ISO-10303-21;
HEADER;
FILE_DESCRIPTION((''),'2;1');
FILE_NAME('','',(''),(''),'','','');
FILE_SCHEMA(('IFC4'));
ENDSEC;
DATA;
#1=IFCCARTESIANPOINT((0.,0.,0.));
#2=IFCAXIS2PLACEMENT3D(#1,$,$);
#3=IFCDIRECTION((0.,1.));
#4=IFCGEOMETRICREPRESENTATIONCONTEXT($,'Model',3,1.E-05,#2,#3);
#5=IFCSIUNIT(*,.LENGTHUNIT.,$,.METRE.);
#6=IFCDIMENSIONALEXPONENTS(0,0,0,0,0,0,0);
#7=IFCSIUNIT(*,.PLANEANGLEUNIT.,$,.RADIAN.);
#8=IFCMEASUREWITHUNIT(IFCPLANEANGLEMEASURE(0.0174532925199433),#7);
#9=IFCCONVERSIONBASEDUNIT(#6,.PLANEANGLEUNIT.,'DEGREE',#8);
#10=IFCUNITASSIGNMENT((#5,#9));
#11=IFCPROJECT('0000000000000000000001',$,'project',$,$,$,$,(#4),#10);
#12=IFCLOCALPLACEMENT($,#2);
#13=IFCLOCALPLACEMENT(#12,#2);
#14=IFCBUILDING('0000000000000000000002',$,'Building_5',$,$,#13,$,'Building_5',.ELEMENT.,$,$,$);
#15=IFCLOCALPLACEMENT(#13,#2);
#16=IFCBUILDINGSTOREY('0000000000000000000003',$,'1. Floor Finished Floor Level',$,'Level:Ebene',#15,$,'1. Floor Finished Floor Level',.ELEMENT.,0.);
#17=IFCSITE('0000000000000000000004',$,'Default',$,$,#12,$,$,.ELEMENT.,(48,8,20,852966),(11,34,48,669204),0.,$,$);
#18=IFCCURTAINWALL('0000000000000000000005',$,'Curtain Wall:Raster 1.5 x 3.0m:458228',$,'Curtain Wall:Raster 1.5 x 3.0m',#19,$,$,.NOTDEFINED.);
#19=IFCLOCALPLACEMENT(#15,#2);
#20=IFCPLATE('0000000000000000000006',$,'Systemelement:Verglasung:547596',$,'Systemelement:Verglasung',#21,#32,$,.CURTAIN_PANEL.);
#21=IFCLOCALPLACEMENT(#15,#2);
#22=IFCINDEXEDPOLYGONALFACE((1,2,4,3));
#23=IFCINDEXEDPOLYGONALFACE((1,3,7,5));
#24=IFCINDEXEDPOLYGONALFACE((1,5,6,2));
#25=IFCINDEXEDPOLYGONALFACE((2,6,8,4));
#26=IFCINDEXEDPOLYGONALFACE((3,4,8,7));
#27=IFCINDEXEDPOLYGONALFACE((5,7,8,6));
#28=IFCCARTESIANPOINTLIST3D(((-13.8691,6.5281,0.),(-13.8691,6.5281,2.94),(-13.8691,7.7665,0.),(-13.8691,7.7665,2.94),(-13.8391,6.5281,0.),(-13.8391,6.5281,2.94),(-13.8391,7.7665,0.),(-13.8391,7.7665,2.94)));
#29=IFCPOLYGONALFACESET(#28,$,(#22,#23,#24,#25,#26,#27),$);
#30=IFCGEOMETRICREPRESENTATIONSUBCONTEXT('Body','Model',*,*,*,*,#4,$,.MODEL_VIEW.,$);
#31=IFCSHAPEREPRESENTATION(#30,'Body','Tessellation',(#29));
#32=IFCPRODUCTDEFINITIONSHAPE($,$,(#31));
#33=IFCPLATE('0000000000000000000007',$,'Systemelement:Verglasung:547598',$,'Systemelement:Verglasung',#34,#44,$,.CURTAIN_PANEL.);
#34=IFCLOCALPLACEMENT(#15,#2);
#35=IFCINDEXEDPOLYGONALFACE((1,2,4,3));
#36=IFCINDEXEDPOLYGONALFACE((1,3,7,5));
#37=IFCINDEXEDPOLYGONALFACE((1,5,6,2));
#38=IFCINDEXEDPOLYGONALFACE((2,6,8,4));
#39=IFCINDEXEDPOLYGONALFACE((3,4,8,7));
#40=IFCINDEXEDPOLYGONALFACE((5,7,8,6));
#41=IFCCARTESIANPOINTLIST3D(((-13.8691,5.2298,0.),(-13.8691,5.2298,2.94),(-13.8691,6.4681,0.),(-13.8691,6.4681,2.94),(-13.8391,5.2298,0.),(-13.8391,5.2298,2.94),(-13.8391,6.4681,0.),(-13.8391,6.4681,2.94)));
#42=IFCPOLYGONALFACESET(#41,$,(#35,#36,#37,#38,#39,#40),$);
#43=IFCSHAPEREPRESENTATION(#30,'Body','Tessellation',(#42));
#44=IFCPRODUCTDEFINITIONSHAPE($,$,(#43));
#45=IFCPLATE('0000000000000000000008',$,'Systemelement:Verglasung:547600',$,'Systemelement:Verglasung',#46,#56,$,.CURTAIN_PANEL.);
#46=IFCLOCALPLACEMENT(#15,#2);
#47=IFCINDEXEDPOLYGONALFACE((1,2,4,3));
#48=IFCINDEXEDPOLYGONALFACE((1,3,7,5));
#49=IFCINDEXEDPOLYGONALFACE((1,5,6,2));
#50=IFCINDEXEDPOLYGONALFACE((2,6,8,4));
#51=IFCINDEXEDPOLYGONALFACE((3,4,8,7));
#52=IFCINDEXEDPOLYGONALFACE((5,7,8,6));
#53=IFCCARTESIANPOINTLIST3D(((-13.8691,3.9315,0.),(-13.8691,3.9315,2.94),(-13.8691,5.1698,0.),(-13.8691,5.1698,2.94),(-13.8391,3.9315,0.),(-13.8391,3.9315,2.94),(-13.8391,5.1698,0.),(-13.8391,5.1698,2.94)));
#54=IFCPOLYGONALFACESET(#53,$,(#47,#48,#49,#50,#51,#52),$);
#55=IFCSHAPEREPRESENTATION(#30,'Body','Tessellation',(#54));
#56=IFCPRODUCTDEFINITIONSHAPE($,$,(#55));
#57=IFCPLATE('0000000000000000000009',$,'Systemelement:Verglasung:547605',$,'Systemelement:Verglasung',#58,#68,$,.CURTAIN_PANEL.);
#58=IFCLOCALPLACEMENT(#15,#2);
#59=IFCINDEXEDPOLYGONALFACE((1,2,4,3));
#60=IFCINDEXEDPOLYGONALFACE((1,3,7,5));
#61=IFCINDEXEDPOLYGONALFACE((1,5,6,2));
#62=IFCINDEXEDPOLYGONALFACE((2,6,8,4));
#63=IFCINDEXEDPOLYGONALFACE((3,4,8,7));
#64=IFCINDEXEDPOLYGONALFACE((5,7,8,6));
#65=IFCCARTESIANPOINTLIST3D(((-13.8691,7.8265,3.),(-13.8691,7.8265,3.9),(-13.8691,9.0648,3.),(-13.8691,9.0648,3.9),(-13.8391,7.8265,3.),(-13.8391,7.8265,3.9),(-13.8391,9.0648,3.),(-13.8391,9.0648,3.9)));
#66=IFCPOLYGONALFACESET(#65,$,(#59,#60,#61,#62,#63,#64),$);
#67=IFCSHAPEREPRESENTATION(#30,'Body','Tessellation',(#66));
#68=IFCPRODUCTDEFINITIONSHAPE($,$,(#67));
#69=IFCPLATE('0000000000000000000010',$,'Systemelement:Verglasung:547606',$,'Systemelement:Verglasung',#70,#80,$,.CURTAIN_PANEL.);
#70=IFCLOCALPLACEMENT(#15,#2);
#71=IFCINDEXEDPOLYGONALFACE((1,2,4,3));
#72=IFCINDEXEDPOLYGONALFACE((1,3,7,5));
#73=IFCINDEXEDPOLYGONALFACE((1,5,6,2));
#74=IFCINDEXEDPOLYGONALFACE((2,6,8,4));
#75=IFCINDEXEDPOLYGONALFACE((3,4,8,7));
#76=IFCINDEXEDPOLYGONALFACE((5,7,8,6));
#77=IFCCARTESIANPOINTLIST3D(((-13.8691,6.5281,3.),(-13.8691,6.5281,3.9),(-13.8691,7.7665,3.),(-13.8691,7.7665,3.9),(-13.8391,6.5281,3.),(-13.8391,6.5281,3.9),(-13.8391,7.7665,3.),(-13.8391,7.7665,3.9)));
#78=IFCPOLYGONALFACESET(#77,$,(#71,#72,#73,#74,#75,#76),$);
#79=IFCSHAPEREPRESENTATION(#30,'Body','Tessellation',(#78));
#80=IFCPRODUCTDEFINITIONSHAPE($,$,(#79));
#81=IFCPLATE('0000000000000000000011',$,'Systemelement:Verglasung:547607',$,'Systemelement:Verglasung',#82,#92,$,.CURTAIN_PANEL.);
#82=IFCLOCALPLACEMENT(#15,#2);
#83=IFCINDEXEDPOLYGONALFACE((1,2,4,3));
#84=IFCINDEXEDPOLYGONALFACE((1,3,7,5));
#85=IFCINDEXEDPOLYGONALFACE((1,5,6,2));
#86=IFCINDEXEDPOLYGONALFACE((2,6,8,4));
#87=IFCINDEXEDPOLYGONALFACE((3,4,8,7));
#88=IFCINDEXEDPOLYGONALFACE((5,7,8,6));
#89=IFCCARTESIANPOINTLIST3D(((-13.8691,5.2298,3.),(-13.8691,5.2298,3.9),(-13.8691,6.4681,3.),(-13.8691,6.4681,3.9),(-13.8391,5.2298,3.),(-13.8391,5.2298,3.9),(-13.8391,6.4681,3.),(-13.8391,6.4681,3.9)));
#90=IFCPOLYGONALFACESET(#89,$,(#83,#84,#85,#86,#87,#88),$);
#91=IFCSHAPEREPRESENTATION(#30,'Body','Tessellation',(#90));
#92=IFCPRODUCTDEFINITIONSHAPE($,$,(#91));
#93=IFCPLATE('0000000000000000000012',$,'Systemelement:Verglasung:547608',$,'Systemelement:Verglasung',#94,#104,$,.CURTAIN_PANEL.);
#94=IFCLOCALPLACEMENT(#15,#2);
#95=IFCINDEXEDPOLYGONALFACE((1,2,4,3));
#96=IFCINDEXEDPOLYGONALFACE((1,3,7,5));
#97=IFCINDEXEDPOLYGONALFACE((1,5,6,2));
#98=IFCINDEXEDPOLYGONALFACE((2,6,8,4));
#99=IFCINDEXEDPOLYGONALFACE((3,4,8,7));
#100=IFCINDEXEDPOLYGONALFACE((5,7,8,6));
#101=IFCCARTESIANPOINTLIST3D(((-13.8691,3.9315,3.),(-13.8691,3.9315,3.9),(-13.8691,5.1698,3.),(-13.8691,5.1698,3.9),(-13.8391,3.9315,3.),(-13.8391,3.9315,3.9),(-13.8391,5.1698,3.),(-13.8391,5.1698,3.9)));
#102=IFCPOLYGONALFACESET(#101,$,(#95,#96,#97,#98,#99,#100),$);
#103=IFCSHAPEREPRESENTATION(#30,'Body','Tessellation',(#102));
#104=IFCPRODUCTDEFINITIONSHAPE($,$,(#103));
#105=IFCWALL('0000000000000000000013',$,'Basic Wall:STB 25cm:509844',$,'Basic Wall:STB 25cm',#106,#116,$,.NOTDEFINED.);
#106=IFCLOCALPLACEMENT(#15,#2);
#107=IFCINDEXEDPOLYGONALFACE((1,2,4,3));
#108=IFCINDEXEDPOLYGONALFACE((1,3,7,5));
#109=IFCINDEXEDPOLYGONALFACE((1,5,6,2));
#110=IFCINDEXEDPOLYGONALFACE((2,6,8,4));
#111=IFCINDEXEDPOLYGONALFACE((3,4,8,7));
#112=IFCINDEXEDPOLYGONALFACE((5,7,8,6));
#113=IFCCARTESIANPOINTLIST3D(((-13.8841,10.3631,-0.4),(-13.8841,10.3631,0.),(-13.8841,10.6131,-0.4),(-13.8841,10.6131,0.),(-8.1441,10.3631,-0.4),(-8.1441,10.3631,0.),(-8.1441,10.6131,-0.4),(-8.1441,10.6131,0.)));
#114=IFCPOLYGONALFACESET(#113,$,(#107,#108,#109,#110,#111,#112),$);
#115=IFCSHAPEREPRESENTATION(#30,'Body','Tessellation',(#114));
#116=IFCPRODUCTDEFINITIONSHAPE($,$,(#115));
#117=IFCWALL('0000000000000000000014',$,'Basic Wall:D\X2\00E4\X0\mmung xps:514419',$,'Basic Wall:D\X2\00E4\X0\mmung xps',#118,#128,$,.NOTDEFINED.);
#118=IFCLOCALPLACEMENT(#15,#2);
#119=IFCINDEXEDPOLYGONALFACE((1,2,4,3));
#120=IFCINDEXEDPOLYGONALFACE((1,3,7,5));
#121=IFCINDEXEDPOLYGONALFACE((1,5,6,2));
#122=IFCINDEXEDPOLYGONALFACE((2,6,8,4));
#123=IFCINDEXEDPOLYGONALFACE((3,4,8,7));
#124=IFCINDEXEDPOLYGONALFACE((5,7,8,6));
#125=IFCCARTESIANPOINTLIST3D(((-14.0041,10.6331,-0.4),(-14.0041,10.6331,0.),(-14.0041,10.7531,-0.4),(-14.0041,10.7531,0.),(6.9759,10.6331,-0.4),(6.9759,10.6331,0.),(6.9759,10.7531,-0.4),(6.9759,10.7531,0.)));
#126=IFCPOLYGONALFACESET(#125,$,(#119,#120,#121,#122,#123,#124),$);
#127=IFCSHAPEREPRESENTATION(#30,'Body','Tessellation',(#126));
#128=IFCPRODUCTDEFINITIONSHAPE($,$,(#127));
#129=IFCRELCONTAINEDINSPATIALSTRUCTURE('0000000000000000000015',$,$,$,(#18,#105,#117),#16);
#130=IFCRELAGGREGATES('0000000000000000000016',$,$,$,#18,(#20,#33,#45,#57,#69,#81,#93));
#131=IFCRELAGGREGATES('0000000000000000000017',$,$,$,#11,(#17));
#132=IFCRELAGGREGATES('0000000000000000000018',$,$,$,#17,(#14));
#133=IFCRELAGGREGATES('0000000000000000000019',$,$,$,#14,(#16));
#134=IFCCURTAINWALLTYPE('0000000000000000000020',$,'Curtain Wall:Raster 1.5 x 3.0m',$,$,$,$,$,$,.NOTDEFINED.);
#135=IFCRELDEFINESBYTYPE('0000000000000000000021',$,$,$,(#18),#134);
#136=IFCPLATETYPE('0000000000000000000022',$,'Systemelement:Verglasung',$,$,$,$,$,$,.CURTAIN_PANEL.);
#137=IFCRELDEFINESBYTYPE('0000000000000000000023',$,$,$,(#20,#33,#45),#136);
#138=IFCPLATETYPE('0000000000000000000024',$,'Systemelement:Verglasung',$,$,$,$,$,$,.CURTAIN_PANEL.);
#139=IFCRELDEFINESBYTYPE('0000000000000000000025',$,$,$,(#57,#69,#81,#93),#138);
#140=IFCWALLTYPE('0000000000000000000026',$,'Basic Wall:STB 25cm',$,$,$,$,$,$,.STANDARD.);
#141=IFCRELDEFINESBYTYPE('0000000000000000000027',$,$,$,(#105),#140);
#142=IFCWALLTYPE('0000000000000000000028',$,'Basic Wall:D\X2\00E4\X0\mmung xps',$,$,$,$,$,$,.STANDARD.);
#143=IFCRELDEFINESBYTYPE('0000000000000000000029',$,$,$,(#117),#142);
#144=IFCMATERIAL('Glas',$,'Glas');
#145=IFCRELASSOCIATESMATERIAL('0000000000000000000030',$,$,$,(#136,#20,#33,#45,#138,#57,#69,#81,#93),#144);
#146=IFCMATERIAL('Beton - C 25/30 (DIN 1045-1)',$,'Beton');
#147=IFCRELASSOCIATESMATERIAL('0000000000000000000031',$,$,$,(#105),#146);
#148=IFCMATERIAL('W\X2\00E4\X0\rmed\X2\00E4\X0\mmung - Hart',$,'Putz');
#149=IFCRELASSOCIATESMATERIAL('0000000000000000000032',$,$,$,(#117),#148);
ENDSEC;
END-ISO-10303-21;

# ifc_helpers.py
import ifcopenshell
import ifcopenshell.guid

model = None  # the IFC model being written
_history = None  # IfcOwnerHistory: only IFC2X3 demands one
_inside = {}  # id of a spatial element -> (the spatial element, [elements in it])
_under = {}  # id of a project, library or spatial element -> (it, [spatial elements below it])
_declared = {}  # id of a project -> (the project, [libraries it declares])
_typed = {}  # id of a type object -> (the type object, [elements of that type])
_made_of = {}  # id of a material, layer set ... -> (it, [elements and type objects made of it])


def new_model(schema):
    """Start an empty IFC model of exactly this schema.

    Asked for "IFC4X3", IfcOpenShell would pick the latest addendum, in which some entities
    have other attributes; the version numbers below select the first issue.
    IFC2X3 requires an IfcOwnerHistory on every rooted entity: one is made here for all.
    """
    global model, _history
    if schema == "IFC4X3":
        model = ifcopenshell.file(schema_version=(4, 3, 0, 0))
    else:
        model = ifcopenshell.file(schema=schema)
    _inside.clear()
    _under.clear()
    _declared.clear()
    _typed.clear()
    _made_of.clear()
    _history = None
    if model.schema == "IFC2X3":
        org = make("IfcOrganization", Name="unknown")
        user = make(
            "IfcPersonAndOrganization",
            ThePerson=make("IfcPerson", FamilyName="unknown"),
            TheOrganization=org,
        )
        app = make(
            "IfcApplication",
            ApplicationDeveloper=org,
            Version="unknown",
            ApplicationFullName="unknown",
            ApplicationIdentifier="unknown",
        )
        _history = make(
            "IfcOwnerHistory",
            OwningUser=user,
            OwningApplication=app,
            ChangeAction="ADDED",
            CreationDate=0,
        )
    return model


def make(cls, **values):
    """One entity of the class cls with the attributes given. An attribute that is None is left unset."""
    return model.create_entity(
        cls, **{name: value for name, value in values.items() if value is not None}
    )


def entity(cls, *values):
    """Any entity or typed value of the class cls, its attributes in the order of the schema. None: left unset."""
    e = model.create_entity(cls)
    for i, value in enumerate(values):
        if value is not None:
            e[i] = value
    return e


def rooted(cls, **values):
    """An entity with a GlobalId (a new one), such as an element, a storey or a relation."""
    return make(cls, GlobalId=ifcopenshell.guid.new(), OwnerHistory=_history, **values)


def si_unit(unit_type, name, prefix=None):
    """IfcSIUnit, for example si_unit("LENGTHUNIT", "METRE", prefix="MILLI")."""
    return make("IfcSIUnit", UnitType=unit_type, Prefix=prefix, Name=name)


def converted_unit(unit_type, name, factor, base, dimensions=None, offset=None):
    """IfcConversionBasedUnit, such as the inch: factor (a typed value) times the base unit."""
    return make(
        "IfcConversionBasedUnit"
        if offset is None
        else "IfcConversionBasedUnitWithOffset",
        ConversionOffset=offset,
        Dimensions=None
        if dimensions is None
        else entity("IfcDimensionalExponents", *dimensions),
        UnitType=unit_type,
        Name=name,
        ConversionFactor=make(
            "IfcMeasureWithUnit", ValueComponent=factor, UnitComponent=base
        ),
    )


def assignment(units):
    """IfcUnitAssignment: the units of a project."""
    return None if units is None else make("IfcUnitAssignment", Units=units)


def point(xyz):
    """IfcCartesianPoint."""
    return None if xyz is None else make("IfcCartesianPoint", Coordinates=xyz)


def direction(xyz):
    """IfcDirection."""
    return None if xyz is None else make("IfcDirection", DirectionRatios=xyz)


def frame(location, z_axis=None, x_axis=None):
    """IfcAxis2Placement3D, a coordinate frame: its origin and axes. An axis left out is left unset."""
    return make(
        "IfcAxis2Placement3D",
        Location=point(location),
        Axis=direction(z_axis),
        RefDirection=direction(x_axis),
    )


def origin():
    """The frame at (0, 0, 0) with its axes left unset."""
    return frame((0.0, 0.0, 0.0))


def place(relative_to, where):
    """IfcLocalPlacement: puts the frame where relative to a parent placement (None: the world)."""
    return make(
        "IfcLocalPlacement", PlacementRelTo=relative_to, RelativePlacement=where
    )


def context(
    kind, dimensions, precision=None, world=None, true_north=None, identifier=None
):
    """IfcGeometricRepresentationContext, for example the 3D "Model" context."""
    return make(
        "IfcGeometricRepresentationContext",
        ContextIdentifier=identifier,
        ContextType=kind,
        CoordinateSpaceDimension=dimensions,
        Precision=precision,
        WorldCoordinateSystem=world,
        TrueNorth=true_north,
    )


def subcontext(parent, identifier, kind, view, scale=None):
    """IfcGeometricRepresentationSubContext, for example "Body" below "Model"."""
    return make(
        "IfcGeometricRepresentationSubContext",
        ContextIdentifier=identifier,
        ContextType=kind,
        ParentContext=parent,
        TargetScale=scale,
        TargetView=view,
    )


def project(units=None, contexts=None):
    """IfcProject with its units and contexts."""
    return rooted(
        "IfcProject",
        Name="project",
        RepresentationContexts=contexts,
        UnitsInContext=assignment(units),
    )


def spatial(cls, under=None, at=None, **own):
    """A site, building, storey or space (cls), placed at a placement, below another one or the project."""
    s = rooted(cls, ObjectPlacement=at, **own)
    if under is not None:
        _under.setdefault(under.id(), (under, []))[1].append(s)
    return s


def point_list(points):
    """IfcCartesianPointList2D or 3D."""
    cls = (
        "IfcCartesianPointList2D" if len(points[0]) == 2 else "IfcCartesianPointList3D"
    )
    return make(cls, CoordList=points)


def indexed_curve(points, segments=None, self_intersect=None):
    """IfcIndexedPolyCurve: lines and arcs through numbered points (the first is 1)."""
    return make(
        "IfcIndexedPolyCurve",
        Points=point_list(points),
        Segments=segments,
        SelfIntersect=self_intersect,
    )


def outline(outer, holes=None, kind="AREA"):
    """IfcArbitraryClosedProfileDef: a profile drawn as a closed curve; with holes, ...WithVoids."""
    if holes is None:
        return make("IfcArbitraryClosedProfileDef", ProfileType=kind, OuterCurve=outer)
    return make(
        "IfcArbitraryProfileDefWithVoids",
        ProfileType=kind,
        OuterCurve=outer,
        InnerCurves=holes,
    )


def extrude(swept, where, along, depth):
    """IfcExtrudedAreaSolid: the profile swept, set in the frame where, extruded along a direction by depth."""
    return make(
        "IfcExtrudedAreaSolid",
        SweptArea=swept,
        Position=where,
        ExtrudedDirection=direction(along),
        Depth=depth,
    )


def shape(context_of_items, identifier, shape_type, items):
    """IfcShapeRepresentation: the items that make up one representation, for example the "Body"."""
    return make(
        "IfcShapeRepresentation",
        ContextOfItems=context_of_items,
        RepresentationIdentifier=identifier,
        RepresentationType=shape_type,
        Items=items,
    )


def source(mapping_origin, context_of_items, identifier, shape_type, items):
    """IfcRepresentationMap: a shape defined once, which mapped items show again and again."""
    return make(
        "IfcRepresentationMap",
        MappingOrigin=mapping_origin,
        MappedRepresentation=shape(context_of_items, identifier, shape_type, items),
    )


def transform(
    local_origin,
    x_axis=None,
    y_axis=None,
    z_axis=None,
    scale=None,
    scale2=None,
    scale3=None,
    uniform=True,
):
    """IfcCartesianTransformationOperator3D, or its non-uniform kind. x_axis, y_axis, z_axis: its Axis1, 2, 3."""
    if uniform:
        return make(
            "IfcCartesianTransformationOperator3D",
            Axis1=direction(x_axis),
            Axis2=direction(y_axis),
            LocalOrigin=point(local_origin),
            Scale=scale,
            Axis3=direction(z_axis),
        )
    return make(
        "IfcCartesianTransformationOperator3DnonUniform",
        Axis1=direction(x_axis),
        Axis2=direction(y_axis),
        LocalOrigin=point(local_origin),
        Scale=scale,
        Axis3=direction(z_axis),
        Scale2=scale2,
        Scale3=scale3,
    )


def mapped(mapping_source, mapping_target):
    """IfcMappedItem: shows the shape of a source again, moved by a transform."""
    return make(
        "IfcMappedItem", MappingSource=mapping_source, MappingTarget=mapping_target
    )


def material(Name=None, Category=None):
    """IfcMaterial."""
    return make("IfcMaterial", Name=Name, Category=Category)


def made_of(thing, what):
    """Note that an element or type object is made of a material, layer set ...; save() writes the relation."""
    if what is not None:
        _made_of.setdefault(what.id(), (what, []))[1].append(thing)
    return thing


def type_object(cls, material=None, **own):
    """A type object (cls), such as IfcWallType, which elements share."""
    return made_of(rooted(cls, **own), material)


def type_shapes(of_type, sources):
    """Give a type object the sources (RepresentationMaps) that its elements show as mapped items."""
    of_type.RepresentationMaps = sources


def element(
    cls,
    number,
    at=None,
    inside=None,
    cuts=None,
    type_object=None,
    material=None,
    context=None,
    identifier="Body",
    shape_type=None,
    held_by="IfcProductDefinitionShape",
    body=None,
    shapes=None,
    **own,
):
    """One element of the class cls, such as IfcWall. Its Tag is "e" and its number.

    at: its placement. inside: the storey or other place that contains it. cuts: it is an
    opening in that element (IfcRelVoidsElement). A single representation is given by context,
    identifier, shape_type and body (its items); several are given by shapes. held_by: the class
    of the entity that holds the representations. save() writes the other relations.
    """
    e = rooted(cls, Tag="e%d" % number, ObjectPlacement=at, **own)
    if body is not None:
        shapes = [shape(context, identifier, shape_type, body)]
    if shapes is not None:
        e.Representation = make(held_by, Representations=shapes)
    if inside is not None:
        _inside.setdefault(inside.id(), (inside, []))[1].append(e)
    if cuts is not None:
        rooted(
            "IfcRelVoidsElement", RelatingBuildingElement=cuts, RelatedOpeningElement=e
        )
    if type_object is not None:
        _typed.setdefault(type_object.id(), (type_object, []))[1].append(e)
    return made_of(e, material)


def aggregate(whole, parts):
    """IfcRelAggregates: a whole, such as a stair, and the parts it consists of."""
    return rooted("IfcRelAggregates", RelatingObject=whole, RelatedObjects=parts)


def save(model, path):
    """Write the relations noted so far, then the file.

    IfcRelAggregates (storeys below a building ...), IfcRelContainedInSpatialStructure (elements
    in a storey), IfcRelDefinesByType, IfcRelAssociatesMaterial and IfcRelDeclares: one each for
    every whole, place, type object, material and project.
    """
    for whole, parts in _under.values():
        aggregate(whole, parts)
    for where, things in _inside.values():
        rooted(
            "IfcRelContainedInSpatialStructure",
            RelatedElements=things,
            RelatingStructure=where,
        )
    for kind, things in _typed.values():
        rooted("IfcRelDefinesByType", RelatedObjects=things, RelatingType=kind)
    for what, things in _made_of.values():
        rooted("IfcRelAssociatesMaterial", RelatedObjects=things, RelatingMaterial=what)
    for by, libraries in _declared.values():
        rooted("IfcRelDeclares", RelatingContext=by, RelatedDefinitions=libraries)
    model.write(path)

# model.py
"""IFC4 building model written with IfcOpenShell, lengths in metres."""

from ifc_helpers import new_model, entity, si_unit, converted_unit, direction, frame, origin, place, context, subcontext, project, spatial, indexed_curve, outline, extrude, source, transform, mapped, material, type_object, type_shapes, element, aggregate, save


model = new_model("IFC4")

# Units and contexts
model_context = context("Model", 3, precision=1e-05, world=origin(), true_north=direction((0.0, 1.0)))
body_context = subcontext(model_context, "Body", "Model", "MODEL_VIEW")
ifc_project = project(units=[si_unit("LENGTHUNIT", "METRE"), converted_unit("PLANEANGLEUNIT", "DEGREE", entity("IfcPlaneAngleMeasure", 0.0174532925199433), si_unit("PLANEANGLEUNIT", "RADIAN"), dimensions=[0, 0, 0, 0, 0, 0, 0])], contexts=[model_context])

# Site, building, storey
site_placement = place(None, origin())
site = spatial("IfcSite", under=ifc_project, at=site_placement, Name="Default", CompositionType="ELEMENT", RefLatitude=(48, 8, 20, 852966), RefLongitude=(11, 34, 48, 669204), RefElevation=0.0)
building_placement = place(site_placement, origin())
building = spatial("IfcBuilding", under=site, at=building_placement, Name="Building_5", LongName="Building_5", CompositionType="ELEMENT")
storey_placement = place(building_placement, origin())
storey = spatial("IfcBuildingStorey", under=building, at=storey_placement, Name="1. Floor Finished Floor Level", ObjectType="Level:Ebene", LongName="1. Floor Finished Floor Level", CompositionType="ELEMENT", Elevation=0.0)

# Curtain wall, plates
curtain_wall_type = type_object("IfcCurtainWallType", Name="Curtain Wall:Raster 1.5 x 3.0m", PredefinedType="NOTDEFINED")
curtain_wall_placement = place(storey_placement, origin())
curtain_wall = element("IfcCurtainWall", 1, at=curtain_wall_placement, inside=storey, type_object=curtain_wall_type, Name="Curtain Wall:Raster 1.5 x 3.0m:458228", ObjectType="Curtain Wall:Raster 1.5 x 3.0m", PredefinedType="NOTDEFINED")
ifc_material_1 = material(Name="Glas", Category="Glas")
plate_type_1 = type_object("IfcPlateType", Name="Systemelement:Verglasung", PredefinedType="CURTAIN_PANEL", material=ifc_material_1)
shared_shape_1 = source(origin(), body_context, "Body", "SweptSolid", [
    extrude(outline(indexed_curve([(-0.015, -0.6192), (0.015, -0.6192), (0.015, 0.6192), (-0.015, 0.6192), (-0.015, -0.6192)], self_intersect=False)), frame((0.0, 0.0, 0.0), z_axis=(0.0, 0.0, 1.0), x_axis=(0.0, 1.0, 0.0)), (0.0, 0.0, 1.0), 2.94),
])
type_shapes(plate_type_1, [shared_shape_1])
plate_1_placement = place(curtain_wall_placement, frame((-13.8541, 7.1473, 0.0), z_axis=(0.0, 0.0, 1.0), x_axis=(0.0, -1.0, 0.0)))
plate_1 = element("IfcPlate", 2, at=plate_1_placement, type_object=plate_type_1, material=ifc_material_1, Name="Systemelement:Verglasung:547596", ObjectType="Systemelement:Verglasung", PredefinedType="CURTAIN_PANEL", context=body_context, shape_type="MappedRepresentation", body=[
    mapped(shared_shape_1, transform((0.0, 0.0, 0.0), scale=1.0)),
])
plate_2_placement = place(curtain_wall_placement, frame((-13.8541, 5.849, 0.0), z_axis=(0.0, 0.0, 1.0), x_axis=(0.0, -1.0, 0.0)))
plate_2 = element("IfcPlate", 3, at=plate_2_placement, type_object=plate_type_1, material=ifc_material_1, Name="Systemelement:Verglasung:547598", ObjectType="Systemelement:Verglasung", PredefinedType="CURTAIN_PANEL", context=body_context, shape_type="MappedRepresentation", body=[
    mapped(shared_shape_1, transform((0.0, 0.0, 0.0), scale=1.0)),
])
plate_3_placement = place(curtain_wall_placement, frame((-13.8541, 4.5506, 0.0), z_axis=(0.0, 0.0, 1.0), x_axis=(0.0, -1.0, 0.0)))
plate_3 = element("IfcPlate", 4, at=plate_3_placement, type_object=plate_type_1, material=ifc_material_1, Name="Systemelement:Verglasung:547600", ObjectType="Systemelement:Verglasung", PredefinedType="CURTAIN_PANEL", context=body_context, shape_type="MappedRepresentation", body=[
    mapped(shared_shape_1, transform((0.0, 0.0, 0.0), scale=1.0)),
])
plate_type_2 = type_object("IfcPlateType", Name="Systemelement:Verglasung", PredefinedType="CURTAIN_PANEL", material=ifc_material_1)
shared_shape_2 = source(origin(), body_context, "Body", "SweptSolid", [
    extrude(outline(indexed_curve([(-0.015, -0.6192), (0.015, -0.6192), (0.015, 0.6192), (-0.015, 0.6192), (-0.015, -0.6192)], self_intersect=False)), frame((0.0, 0.0, 0.0), z_axis=(0.0, 0.0, 1.0), x_axis=(0.0, 1.0, 0.0)), (0.0, 0.0, 1.0), 0.9),
])
type_shapes(plate_type_2, [shared_shape_2])
plate_4_placement = place(curtain_wall_placement, frame((-13.8541, 8.4456, 3.0), z_axis=(0.0, 0.0, 1.0), x_axis=(0.0, -1.0, 0.0)))
plate_4 = element("IfcPlate", 5, at=plate_4_placement, type_object=plate_type_2, material=ifc_material_1, Name="Systemelement:Verglasung:547605", ObjectType="Systemelement:Verglasung", PredefinedType="CURTAIN_PANEL", context=body_context, shape_type="MappedRepresentation", body=[
    mapped(shared_shape_2, transform((0.0, 0.0, 0.0), scale=1.0)),
])
plate_5_placement = place(curtain_wall_placement, frame((-13.8541, 7.1473, 3.0), z_axis=(0.0, 0.0, 1.0), x_axis=(0.0, -1.0, 0.0)))
plate_5 = element("IfcPlate", 6, at=plate_5_placement, type_object=plate_type_2, material=ifc_material_1, Name="Systemelement:Verglasung:547606", ObjectType="Systemelement:Verglasung", PredefinedType="CURTAIN_PANEL", context=body_context, shape_type="MappedRepresentation", body=[
    mapped(shared_shape_2, transform((0.0, 0.0, 0.0), scale=1.0)),
])
plate_6_placement = place(curtain_wall_placement, frame((-13.8541, 5.849, 3.0), z_axis=(0.0, 0.0, 1.0), x_axis=(0.0, -1.0, 0.0)))
plate_6 = element("IfcPlate", 7, at=plate_6_placement, type_object=plate_type_2, material=ifc_material_1, Name="Systemelement:Verglasung:547607", ObjectType="Systemelement:Verglasung", PredefinedType="CURTAIN_PANEL", context=body_context, shape_type="MappedRepresentation", body=[
    mapped(shared_shape_2, transform((0.0, 0.0, 0.0), scale=1.0)),
])
plate_7_placement = place(curtain_wall_placement, frame((-13.8541, 4.5506, 3.0), z_axis=(0.0, 0.0, 1.0), x_axis=(0.0, -1.0, 0.0)))
plate_7 = element("IfcPlate", 8, at=plate_7_placement, type_object=plate_type_2, material=ifc_material_1, Name="Systemelement:Verglasung:547608", ObjectType="Systemelement:Verglasung", PredefinedType="CURTAIN_PANEL", context=body_context, shape_type="MappedRepresentation", body=[
    mapped(shared_shape_2, transform((0.0, 0.0, 0.0), scale=1.0)),
])
aggregate(curtain_wall, [plate_1, plate_2, plate_3, plate_4, plate_5, plate_6, plate_7])

# Shared definitions
ifc_material_2 = material(Name="Wärmedämmung - Hart", Category="Putz")

# Walls
ifc_material_3 = material(Name="Beton - C 25/30 (DIN 1045-1)", Category="Beton")
wall_type_1 = type_object("IfcWallType", Name="Basic Wall:STB 25cm", PredefinedType="STANDARD")
wall_1_placement = place(storey_placement, frame((-13.8841, 10.4881, -0.4)))
element("IfcWall", 9, at=wall_1_placement, inside=storey, type_object=wall_type_1, material=ifc_material_3, Name="Basic Wall:STB 25cm:509844", ObjectType="Basic Wall:STB 25cm", PredefinedType="NOTDEFINED", context=body_context, shape_type="SweptSolid", body=[
    extrude(outline(indexed_curve([(5.74, 0.125), (0.0, 0.125), (0.0, -0.125), (5.74, -0.125), (5.74, 0.125)], self_intersect=False)), origin(), (0.0, 0.0, 1.0), 0.4),
])
wall_type_2 = type_object("IfcWallType", Name="Basic Wall:Dämmung xps", PredefinedType="STANDARD")
wall_2_placement = place(storey_placement, frame((-14.0041, 10.6931, -0.4)))
element("IfcWall", 10, at=wall_2_placement, inside=storey, type_object=wall_type_2, material=ifc_material_2, Name="Basic Wall:Dämmung xps:514419", ObjectType="Basic Wall:Dämmung xps", PredefinedType="NOTDEFINED", context=body_context, shape_type="SweptSolid", body=[
    extrude(outline(indexed_curve([(20.98, 0.06), (0.0, 0.06), (0.0, -0.06), (20.98, -0.06), (20.98, 0.06)], self_intersect=False)), origin(), (0.0, 0.0, 1.0), 0.4),
])

save(model, "model.ifc")
